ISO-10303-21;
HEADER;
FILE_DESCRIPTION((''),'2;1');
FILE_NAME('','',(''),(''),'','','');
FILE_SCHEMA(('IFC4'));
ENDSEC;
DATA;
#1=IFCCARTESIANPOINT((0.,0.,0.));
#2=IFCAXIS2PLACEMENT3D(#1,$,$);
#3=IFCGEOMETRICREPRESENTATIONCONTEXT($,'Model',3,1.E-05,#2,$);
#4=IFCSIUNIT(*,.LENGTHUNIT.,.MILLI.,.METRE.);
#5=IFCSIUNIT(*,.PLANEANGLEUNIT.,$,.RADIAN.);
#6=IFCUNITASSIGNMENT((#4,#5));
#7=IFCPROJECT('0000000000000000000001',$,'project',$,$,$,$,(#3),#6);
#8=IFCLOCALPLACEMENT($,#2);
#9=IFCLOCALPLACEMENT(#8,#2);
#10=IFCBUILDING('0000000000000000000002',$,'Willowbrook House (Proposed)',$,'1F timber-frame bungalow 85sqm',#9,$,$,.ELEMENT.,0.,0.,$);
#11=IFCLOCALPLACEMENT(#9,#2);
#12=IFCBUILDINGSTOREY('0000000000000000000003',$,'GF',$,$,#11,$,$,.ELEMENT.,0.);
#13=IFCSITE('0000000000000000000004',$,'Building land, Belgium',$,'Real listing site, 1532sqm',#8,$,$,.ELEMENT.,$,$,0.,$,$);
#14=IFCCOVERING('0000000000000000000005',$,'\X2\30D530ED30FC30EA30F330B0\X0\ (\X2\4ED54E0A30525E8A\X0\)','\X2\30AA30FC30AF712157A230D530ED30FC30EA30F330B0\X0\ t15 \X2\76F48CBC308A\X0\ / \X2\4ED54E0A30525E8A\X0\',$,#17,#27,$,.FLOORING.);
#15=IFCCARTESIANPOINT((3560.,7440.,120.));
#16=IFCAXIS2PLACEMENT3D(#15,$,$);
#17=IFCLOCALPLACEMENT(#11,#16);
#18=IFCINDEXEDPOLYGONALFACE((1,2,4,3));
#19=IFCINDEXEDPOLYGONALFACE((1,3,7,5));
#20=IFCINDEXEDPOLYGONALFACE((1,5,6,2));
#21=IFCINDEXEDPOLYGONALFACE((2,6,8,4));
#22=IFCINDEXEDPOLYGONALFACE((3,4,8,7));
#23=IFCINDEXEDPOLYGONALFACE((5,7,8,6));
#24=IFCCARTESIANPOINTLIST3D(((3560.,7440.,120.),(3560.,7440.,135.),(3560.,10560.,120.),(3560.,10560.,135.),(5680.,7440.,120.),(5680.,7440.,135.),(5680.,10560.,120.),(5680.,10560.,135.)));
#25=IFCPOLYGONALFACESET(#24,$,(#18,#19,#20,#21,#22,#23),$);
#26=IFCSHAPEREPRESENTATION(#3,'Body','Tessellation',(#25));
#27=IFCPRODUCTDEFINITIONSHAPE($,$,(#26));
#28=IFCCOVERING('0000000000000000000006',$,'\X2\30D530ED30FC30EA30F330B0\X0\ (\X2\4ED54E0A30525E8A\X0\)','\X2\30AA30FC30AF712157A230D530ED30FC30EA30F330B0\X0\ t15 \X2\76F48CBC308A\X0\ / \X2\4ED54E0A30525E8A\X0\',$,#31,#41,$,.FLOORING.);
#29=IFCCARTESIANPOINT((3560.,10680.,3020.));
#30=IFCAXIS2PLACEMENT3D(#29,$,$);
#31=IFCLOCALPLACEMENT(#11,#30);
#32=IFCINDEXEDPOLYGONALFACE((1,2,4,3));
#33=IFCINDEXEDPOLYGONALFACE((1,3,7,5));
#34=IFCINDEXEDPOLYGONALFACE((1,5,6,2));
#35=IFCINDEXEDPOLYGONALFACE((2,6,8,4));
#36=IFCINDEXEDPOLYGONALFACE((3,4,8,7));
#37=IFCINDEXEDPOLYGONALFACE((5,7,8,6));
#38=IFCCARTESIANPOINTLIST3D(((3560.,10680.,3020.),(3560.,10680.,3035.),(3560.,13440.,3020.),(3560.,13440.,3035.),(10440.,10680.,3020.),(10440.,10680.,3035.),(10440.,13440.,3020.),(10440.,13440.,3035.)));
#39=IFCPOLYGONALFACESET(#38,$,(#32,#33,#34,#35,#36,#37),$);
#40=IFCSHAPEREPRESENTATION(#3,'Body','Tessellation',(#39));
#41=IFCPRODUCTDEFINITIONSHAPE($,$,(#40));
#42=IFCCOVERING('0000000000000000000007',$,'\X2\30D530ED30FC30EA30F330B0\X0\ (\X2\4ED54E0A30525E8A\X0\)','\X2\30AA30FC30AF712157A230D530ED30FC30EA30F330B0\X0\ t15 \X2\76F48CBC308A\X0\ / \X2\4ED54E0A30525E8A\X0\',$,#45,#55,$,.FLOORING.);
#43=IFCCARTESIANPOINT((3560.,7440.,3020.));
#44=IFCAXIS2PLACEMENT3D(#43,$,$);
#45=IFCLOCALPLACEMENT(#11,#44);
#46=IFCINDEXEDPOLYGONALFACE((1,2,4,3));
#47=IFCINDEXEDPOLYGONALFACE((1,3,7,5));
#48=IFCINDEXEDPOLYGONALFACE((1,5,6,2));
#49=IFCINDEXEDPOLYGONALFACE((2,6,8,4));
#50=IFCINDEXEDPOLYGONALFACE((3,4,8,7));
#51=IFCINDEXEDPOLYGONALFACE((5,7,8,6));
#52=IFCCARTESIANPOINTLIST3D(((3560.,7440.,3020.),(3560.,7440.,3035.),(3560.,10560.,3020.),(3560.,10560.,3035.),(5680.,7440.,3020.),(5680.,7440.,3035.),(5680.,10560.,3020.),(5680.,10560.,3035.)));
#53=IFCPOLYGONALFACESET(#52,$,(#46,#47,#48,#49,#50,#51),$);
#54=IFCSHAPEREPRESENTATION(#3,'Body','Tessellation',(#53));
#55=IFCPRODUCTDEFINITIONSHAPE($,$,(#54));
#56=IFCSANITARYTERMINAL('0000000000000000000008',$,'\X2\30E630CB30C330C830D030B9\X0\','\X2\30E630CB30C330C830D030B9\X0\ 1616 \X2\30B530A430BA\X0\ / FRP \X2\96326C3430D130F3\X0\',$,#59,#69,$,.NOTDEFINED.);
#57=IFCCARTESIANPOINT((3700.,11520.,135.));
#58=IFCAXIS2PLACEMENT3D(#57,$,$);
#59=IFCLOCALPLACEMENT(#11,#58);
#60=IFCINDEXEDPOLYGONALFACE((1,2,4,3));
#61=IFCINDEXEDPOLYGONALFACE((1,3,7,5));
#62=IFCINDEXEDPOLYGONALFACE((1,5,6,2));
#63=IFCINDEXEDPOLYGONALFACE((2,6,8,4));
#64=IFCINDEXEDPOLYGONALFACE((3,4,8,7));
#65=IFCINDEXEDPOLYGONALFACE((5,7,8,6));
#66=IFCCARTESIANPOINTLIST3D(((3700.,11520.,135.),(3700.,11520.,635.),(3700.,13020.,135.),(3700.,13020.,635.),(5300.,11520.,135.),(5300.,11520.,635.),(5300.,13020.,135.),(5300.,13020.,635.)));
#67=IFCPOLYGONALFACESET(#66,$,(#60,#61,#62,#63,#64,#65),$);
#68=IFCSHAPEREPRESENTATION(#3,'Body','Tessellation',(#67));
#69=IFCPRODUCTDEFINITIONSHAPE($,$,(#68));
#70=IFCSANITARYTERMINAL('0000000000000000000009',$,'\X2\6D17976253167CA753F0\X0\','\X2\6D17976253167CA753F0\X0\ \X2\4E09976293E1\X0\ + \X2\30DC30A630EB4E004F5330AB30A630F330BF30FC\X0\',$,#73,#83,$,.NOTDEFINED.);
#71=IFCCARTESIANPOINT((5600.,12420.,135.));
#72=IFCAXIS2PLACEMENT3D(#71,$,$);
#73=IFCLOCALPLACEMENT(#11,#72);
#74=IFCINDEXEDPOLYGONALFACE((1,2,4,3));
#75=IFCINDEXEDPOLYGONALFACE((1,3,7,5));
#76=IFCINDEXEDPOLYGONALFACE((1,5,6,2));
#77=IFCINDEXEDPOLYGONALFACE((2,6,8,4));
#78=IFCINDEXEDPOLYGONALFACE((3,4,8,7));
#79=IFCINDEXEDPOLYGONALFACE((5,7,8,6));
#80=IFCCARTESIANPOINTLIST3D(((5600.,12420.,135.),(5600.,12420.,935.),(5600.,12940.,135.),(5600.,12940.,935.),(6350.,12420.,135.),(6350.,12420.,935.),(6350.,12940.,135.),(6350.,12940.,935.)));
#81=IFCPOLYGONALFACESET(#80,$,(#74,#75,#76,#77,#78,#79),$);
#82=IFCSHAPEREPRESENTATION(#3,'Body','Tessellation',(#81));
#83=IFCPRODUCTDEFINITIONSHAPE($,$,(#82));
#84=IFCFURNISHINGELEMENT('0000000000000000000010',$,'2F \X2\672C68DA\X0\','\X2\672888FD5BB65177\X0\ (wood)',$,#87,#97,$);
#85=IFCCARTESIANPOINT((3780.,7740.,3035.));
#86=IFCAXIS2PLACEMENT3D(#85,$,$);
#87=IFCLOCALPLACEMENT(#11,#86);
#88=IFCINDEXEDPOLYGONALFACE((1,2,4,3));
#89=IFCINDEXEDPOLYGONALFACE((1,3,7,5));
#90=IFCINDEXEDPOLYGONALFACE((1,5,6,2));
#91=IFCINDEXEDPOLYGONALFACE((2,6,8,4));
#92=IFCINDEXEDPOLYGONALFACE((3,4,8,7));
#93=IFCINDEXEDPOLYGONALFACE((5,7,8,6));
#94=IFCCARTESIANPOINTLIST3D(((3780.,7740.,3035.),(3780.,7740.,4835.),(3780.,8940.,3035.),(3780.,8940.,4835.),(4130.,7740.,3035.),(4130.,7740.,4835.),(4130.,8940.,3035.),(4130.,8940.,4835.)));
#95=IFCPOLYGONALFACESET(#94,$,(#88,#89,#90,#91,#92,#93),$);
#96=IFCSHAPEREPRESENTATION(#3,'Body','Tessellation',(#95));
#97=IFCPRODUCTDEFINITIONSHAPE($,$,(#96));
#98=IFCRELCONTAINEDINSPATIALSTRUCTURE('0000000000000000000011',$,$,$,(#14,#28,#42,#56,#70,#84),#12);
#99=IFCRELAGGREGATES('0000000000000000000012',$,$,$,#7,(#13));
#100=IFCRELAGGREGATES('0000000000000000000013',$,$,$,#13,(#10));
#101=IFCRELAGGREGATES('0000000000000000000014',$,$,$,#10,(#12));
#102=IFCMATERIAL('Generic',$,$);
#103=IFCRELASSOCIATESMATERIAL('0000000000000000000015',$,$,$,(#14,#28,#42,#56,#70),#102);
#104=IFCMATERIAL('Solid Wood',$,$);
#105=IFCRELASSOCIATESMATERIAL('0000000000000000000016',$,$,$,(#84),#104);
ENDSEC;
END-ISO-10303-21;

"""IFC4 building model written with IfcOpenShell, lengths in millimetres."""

from ifc_helpers import new_model, si_unit, frame, frame_2d, origin, place, context, project, spatial, rectangle, extrude, material, element, save


model = new_model("IFC4")

# Units and contexts
model_context = context("Model", 3, precision=1e-05, world=origin())
ifc_project = project(units=[si_unit("LENGTHUNIT", "METRE", prefix="MILLI"), si_unit("PLANEANGLEUNIT", "RADIAN")], contexts=[model_context])

# Site, building, storey
site_placement = place(None, origin())
site = spatial("IfcSite", under=ifc_project, at=site_placement, Name="Building land, Belgium", ObjectType="Real listing site, 1532sqm", CompositionType="ELEMENT", RefElevation=0.0)
building_placement = place(site_placement, origin())
building = spatial("IfcBuilding", under=site, at=building_placement, Name="Willowbrook House (Proposed)", ObjectType="1F timber-frame bungalow 85sqm", CompositionType="ELEMENT", ElevationOfRefHeight=0.0, ElevationOfTerrain=0.0)
storey_placement = place(building_placement, origin())
storey = spatial("IfcBuildingStorey", under=building, at=storey_placement, Name="GF", CompositionType="ELEMENT", Elevation=0.0)

# Shared definitions
ifc_material_1 = material(Name="Solid Wood")

# Coverings
ifc_material_2 = material(Name="Generic")
covering_1_placement = place(storey_placement, frame((3560.0, 7440.0, 120.0)))
element("IfcCovering", 1, at=covering_1_placement, inside=storey, material=ifc_material_2, Name="フローリング (仕上げ床)", Description="オーク無垢フローリング t15 直貼り / 仕上げ床", PredefinedType="FLOORING", context=model_context, shape_type="SweptSolid", body=[
    extrude(rectangle(XDim=2120.0, YDim=3120.0, at=frame_2d((1060.0, 1560.0))), frame((3560.0, 7440.0, 120.0)), (0.0, 0.0, 1.0), 15.0),
])
covering_2_placement = place(storey_placement, frame((3560.0, 10680.0, 3020.0)))
element("IfcCovering", 2, at=covering_2_placement, inside=storey, material=ifc_material_2, Name="フローリング (仕上げ床)", Description="オーク無垢フローリング t15 直貼り / 仕上げ床", PredefinedType="FLOORING", context=model_context, shape_type="SweptSolid", body=[
    extrude(rectangle(XDim=6880.0, YDim=2760.0, at=frame_2d((3440.0, 1380.0))), frame((3560.0, 10680.0, 3020.0)), (0.0, 0.0, 1.0), 15.0),
])
covering_3_placement = place(storey_placement, frame((3560.0, 7440.0, 3020.0)))
element("IfcCovering", 3, at=covering_3_placement, inside=storey, material=ifc_material_2, Name="フローリング (仕上げ床)", Description="オーク無垢フローリング t15 直貼り / 仕上げ床", PredefinedType="FLOORING", context=model_context, shape_type="SweptSolid", body=[
    extrude(rectangle(XDim=2120.0, YDim=3120.0, at=frame_2d((1060.0, 1560.0))), frame((3560.0, 7440.0, 3020.0)), (0.0, 0.0, 1.0), 15.0),
])

# Sanitary terminals
sanitary_terminal_1_placement = place(storey_placement, frame((3700.0, 11520.0, 135.0)))
element("IfcSanitaryTerminal", 4, at=sanitary_terminal_1_placement, inside=storey, material=ifc_material_2, Name="ユニットバス", Description="ユニットバス 1616 サイズ / FRP 防水パン", PredefinedType="NOTDEFINED", context=model_context, shape_type="SweptSolid", body=[
    extrude(rectangle(XDim=1600.0, YDim=1500.0, at=frame_2d((800.0, 750.0))), frame((3700.0, 11520.0, 135.0)), (0.0, 0.0, 1.0), 500.0),
])
sanitary_terminal_2_placement = place(storey_placement, frame((5600.0, 12420.0, 135.0)))
element("IfcSanitaryTerminal", 5, at=sanitary_terminal_2_placement, inside=storey, material=ifc_material_2, Name="洗面化粧台", Description="洗面化粧台 三面鏡 + ボウル一体カウンター", PredefinedType="NOTDEFINED", context=model_context, shape_type="SweptSolid", body=[
    extrude(rectangle(XDim=750.0, YDim=520.0, at=frame_2d((375.0, 260.0))), frame((5600.0, 12420.0, 135.0)), (0.0, 0.0, 1.0), 800.0),
])

# Furnishing element
furnishing_placement = place(storey_placement, frame((3780.0, 7740.0, 3035.0)))
element("IfcFurnishingElement", 6, at=furnishing_placement, inside=storey, material=ifc_material_1, Name="2F 本棚", Description="木製家具 (wood)", context=model_context, shape_type="SweptSolid", body=[
    extrude(rectangle(XDim=350.0, YDim=1200.0, at=frame_2d((175.0, 600.0))), frame((3780.0, 7740.0, 3035.0)), (0.0, 0.0, 1.0), 1800.0),
])

save(model, "model.ifc")
